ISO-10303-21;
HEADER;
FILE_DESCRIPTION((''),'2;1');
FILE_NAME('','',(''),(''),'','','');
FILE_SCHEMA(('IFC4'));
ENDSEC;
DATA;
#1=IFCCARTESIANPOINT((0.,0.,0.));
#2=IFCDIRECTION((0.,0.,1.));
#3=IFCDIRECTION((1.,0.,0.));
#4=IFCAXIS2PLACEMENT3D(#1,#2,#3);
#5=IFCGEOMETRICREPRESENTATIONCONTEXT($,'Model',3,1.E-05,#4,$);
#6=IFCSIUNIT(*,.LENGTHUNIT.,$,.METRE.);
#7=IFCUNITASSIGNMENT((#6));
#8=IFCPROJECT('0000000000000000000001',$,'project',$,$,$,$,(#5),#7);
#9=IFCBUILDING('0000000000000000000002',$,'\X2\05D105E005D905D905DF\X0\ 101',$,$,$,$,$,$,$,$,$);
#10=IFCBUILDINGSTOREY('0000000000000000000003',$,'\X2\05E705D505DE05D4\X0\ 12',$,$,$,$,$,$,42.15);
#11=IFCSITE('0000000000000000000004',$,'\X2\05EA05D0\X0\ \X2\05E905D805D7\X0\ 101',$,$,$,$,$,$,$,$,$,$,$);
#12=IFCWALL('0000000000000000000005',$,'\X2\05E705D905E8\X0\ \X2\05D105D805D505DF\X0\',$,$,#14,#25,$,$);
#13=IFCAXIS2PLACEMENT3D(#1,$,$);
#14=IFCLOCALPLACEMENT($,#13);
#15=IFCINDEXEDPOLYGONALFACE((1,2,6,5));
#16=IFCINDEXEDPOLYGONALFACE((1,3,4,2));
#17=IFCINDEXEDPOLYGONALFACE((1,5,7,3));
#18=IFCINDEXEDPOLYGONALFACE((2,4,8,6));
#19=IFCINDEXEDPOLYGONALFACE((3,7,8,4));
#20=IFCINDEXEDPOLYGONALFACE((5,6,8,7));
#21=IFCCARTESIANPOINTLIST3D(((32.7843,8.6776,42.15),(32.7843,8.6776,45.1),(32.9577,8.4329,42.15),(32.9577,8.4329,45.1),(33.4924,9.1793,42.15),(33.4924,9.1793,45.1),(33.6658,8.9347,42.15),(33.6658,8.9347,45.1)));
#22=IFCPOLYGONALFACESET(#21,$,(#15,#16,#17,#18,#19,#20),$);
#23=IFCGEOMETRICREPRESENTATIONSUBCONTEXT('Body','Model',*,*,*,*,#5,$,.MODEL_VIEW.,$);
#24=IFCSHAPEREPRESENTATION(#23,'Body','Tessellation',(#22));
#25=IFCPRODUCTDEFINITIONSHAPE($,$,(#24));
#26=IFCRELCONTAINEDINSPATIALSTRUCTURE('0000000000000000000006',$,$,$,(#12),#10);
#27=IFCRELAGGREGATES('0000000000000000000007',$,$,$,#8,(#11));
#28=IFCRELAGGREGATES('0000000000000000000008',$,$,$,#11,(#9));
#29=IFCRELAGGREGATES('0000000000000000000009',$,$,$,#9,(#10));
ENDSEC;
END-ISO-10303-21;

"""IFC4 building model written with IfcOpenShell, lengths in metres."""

from ifc_helpers import new_model, si_unit, frame, origin_with_axes, context, subcontext, project, spatial, polyline, outline, extrude, element, save


model = new_model("IFC4")

# Units and contexts
model_context = context("Model", 3, precision=1e-05, world=origin_with_axes())
body_context = subcontext(model_context, "Body", "Model", "MODEL_VIEW")
ifc_project = project(units=[si_unit("LENGTHUNIT", "METRE")], contexts=[model_context])

# Site, building, storey
site = spatial("IfcSite", under=ifc_project, Name="תא שטח 101")
building = spatial("IfcBuilding", under=site, Name="בניין 101")
storey = spatial("IfcBuildingStorey", under=building, Name="קומה 12", Elevation=42.15)

# Wall
element("IfcWall", 1, inside=storey, Name="קיר בטון", context=body_context, shape_type="SweptSolid", body=[
    extrude(outline(polyline([(33.4924, 9.1793), (32.7843, 8.6776), (32.9577, 8.4329), (33.6658, 8.9347), (33.4924, 9.1793)])), frame((0.0, 0.0, 42.15)), (0.0, 0.0, 1.0), 2.95),
])

save(model, "model.ifc")
